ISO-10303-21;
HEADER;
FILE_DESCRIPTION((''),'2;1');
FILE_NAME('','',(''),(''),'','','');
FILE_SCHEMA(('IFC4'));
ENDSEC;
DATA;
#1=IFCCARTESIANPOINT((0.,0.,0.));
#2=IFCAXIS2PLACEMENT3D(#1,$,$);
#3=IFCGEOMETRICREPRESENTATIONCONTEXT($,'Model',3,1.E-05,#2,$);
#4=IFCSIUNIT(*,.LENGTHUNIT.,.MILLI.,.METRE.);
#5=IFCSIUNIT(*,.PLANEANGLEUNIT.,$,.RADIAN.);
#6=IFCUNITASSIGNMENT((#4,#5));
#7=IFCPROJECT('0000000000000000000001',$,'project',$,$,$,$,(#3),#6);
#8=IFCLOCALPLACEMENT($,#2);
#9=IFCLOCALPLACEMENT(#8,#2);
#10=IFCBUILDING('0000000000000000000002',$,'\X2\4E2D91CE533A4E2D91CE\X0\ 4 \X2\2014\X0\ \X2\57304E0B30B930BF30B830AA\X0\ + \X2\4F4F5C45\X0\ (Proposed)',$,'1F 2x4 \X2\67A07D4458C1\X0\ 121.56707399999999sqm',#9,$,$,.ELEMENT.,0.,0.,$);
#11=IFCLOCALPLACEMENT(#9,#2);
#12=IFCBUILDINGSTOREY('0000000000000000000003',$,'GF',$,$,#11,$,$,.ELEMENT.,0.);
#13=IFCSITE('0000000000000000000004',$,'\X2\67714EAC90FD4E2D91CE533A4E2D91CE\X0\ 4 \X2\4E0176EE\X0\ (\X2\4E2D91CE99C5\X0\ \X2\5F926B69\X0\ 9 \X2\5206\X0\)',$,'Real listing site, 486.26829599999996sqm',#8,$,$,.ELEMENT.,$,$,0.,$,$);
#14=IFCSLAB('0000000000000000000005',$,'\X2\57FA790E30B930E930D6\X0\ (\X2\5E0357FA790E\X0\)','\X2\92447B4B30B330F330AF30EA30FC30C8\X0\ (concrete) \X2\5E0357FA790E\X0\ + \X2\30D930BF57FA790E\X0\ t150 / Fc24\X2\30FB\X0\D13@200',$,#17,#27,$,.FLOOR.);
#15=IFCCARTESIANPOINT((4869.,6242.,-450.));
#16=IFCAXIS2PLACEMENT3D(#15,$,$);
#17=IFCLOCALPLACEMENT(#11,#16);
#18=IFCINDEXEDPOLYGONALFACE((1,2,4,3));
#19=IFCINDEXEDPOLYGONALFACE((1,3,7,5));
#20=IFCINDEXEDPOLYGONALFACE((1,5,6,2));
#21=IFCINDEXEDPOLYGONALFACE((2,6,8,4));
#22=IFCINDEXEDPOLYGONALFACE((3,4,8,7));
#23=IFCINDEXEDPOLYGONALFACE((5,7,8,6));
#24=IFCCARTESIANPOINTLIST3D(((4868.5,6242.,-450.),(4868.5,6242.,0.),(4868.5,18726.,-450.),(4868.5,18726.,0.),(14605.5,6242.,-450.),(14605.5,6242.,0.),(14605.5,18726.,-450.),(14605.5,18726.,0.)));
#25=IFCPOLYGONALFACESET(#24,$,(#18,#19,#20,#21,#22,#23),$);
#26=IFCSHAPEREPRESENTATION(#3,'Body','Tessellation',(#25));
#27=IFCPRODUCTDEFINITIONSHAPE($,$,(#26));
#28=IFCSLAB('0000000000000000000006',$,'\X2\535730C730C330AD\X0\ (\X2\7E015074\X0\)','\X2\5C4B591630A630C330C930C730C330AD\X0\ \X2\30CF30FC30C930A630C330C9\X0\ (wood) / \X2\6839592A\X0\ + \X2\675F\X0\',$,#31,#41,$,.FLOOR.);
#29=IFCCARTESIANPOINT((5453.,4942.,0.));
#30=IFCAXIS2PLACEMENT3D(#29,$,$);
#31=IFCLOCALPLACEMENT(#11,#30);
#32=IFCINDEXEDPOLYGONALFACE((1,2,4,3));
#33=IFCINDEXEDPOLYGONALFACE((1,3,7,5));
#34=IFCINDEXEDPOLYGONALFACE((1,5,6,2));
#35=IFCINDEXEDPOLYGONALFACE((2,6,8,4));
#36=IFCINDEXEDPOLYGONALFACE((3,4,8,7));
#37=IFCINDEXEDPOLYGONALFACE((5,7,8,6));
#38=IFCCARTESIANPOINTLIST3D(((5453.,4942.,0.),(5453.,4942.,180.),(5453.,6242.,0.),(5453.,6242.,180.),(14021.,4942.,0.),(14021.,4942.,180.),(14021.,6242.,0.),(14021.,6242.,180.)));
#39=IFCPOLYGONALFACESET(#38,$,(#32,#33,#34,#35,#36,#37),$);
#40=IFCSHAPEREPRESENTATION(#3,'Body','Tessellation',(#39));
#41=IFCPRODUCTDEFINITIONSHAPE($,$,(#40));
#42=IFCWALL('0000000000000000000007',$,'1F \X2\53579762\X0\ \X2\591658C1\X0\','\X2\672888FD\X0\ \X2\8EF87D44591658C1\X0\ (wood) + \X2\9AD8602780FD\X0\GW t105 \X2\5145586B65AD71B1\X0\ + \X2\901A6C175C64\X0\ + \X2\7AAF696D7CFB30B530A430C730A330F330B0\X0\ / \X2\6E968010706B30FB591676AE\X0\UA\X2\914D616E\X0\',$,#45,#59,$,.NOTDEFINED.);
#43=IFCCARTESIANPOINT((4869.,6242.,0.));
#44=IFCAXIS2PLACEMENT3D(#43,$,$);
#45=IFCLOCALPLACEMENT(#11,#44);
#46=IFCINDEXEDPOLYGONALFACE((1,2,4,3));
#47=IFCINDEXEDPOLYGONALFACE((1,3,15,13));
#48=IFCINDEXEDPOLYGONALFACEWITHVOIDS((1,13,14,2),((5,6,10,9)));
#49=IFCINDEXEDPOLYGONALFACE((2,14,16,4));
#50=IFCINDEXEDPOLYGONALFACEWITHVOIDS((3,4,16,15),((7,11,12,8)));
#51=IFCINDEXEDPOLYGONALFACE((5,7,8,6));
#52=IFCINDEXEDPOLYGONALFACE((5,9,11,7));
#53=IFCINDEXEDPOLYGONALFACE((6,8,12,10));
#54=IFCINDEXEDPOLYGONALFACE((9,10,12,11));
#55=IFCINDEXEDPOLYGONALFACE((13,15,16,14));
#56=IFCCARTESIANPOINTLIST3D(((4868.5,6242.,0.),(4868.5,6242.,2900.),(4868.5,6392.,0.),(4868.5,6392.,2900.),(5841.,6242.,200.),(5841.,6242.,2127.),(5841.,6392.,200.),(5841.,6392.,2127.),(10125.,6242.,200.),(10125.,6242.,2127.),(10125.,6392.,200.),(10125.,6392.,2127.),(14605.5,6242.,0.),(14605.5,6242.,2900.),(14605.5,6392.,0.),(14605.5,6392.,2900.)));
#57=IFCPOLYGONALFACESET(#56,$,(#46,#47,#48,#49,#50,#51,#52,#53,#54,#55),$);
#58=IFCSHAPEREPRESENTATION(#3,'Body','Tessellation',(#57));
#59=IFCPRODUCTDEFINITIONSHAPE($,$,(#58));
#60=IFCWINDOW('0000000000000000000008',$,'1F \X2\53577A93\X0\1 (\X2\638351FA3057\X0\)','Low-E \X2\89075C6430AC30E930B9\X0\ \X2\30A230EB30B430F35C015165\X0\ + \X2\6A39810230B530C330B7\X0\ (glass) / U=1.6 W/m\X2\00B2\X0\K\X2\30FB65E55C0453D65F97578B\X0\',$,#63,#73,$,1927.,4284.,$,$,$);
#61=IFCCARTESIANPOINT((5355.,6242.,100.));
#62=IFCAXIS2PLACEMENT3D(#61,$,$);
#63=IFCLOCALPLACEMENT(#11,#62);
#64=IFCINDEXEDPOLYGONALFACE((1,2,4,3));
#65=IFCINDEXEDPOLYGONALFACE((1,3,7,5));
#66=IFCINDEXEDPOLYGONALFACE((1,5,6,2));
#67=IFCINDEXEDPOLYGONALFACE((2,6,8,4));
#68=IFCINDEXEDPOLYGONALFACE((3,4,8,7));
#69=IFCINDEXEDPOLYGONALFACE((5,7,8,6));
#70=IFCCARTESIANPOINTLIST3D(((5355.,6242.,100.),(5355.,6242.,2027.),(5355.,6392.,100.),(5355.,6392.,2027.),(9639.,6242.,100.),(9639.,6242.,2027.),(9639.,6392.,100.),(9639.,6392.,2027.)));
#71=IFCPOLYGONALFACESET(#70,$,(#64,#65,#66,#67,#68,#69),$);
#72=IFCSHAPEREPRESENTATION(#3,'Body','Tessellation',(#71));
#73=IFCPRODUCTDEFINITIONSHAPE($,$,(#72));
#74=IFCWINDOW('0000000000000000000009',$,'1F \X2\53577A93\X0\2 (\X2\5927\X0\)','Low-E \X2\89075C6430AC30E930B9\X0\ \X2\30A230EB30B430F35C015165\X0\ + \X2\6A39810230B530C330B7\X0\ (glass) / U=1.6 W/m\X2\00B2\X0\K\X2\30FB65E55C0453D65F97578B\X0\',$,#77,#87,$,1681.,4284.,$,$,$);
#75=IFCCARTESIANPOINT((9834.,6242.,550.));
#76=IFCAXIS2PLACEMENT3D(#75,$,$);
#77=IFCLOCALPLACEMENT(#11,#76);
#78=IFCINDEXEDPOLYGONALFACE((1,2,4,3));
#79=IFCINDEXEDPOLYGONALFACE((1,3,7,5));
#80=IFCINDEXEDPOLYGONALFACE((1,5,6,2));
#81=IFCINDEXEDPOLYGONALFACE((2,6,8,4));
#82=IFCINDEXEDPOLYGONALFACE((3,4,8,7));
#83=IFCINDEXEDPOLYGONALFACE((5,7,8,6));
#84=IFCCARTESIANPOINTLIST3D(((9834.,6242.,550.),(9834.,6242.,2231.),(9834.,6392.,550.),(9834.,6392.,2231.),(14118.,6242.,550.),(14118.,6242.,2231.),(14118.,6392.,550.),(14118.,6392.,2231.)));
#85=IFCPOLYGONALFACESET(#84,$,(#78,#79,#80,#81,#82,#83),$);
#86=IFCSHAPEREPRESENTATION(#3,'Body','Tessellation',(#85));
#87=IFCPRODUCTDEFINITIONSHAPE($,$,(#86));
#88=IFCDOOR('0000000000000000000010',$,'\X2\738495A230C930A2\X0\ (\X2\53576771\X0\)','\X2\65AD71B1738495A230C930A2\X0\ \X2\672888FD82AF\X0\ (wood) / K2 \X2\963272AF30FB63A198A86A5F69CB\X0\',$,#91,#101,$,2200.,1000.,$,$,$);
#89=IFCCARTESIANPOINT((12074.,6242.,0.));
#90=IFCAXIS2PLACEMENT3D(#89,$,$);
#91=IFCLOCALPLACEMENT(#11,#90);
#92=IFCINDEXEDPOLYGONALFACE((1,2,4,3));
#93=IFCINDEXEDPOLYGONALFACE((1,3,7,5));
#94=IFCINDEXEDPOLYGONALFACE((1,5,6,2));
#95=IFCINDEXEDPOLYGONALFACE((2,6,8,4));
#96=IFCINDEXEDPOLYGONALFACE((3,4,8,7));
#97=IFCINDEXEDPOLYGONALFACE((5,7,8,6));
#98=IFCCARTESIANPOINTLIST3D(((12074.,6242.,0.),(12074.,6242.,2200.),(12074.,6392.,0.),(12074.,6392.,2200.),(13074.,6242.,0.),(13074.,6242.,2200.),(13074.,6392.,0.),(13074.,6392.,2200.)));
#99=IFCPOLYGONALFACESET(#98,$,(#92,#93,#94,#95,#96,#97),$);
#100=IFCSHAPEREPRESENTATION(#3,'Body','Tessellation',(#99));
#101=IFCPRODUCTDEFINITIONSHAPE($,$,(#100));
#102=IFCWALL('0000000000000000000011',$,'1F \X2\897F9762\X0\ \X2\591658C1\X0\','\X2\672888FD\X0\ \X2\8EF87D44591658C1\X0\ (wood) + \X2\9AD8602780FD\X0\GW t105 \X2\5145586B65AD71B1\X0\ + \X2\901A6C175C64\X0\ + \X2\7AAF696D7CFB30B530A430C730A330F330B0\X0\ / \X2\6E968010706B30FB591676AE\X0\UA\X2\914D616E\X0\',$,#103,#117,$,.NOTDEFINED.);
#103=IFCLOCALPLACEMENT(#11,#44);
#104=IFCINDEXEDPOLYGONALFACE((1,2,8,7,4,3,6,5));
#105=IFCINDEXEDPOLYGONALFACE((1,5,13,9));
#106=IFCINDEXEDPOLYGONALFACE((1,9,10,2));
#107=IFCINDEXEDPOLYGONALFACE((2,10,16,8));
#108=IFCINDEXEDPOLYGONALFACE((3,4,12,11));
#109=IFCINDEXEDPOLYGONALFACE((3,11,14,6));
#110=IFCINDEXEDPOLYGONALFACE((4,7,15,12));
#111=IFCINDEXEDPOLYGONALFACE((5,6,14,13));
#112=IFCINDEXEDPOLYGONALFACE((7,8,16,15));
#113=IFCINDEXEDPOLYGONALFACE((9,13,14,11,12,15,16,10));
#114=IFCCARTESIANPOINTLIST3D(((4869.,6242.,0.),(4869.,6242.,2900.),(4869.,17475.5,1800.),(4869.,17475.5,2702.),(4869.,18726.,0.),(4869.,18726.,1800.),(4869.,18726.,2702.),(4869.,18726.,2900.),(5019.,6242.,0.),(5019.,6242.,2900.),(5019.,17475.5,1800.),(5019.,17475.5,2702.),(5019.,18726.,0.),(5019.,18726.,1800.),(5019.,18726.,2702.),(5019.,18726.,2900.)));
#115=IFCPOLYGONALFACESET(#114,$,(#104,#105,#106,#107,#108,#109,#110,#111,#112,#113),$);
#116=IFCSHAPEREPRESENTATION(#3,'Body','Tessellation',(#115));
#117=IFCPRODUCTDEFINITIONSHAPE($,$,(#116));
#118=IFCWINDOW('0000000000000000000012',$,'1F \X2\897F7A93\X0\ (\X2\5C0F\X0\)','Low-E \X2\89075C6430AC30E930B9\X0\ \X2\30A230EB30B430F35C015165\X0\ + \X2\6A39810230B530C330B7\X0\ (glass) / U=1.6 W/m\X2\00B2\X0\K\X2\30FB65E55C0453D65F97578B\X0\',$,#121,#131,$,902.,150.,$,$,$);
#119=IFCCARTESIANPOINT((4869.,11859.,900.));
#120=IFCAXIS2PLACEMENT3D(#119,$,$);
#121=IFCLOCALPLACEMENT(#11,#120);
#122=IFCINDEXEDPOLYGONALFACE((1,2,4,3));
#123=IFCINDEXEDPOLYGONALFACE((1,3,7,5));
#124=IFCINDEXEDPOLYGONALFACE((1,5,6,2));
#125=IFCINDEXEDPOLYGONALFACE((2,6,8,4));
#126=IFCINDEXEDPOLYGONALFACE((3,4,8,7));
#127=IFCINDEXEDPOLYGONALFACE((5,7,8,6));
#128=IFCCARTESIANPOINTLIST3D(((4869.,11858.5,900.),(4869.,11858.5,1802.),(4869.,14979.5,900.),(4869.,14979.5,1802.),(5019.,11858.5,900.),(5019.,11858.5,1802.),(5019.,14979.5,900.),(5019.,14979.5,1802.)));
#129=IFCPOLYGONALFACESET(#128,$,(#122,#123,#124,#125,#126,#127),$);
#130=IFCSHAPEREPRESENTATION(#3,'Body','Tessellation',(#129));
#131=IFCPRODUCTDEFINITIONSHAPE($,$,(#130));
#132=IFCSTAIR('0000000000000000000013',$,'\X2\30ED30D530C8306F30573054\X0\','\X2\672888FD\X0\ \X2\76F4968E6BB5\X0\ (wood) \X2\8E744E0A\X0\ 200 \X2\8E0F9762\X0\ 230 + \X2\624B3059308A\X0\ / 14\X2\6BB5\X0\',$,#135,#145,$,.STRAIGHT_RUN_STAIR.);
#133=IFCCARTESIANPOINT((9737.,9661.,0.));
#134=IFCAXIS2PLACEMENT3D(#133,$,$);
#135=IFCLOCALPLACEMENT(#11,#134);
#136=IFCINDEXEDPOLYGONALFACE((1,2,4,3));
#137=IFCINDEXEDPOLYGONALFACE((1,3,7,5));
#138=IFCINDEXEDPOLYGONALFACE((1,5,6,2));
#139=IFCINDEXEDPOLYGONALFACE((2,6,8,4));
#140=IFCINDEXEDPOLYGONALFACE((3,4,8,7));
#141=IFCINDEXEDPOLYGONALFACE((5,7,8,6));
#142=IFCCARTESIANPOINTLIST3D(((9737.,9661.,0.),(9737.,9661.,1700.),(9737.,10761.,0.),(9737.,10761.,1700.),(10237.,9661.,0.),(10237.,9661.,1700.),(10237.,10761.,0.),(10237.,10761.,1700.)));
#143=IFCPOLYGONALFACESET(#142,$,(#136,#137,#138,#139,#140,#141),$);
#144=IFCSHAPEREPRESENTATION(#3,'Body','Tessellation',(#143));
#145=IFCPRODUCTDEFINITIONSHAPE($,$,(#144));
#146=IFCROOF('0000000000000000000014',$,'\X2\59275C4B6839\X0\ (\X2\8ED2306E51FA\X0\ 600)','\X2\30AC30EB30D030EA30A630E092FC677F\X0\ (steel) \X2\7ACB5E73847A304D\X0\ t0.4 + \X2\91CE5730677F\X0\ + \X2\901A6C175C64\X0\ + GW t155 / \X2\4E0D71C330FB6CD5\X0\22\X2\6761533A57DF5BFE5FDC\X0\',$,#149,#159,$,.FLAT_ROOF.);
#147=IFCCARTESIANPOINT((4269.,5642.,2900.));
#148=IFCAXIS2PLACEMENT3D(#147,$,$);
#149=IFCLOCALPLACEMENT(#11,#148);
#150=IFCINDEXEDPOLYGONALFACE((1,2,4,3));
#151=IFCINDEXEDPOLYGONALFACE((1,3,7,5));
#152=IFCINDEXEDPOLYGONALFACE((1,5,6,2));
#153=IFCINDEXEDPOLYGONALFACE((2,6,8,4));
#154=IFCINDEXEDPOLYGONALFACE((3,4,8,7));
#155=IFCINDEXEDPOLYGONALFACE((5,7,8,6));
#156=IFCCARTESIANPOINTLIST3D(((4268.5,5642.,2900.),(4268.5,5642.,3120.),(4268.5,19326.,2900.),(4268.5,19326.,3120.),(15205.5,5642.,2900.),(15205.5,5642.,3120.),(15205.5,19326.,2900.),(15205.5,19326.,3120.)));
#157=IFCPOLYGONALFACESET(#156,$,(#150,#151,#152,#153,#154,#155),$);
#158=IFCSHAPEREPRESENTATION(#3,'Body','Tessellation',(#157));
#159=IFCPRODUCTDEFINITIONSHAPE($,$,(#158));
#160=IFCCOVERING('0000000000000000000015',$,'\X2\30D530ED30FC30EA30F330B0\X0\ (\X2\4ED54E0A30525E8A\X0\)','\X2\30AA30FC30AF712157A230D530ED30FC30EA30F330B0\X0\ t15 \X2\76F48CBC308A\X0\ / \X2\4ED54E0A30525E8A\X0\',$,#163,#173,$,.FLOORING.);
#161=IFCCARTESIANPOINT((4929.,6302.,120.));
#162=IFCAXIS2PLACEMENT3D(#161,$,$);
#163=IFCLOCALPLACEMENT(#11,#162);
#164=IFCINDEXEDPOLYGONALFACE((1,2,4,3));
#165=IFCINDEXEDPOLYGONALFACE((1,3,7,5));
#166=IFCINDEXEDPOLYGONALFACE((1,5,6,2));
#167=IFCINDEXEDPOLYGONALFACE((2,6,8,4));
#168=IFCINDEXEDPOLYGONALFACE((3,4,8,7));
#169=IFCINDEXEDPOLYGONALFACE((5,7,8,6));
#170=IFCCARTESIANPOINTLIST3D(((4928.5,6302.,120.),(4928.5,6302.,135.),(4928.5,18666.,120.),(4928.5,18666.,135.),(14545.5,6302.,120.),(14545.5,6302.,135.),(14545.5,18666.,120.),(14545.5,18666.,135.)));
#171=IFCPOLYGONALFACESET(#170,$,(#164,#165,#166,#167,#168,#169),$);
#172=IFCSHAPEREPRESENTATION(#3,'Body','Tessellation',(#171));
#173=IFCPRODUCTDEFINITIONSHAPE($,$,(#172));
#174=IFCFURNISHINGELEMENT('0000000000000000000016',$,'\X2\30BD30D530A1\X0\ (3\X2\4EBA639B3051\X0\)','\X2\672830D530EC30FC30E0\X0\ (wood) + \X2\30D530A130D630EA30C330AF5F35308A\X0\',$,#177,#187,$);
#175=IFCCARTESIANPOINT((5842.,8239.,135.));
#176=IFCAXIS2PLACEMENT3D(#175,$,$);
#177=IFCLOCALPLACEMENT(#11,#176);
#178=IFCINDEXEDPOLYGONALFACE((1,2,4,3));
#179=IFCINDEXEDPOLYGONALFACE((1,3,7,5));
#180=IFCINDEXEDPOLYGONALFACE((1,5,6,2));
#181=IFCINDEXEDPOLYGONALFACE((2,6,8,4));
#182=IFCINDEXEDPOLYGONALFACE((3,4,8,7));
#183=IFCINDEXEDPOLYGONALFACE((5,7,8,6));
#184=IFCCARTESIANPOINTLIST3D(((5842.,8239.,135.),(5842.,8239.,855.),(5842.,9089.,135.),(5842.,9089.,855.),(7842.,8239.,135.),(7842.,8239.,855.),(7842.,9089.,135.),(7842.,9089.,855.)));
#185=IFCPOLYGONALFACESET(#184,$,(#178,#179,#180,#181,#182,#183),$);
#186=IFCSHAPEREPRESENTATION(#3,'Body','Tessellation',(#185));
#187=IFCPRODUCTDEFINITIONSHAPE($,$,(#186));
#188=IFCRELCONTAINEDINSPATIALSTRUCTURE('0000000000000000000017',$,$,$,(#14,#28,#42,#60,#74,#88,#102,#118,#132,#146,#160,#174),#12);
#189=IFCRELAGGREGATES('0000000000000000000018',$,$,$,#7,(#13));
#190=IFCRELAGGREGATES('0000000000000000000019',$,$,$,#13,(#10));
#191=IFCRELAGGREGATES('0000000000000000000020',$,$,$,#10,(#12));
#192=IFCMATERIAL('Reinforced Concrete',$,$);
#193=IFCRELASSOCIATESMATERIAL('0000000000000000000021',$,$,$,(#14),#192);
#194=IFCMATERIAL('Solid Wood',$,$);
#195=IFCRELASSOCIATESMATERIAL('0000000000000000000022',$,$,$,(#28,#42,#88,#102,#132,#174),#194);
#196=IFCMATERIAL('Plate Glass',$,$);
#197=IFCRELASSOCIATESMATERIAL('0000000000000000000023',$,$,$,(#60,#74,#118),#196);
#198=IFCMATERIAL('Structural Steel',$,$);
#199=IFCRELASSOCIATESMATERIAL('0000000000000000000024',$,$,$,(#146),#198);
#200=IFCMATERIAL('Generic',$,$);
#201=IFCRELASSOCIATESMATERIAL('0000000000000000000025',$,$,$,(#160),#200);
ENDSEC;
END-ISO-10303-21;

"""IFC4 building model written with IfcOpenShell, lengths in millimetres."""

from ifc_helpers import new_model, si_unit, frame, frame_2d, origin, place, context, project, spatial, rectangle, extrude, material, element, fill, save


model = new_model("IFC4")

# Units and contexts
model_context = context("Model", 3, precision=1e-05, world=origin())
ifc_project = project(units=[si_unit("LENGTHUNIT", "METRE", prefix="MILLI"), si_unit("PLANEANGLEUNIT", "RADIAN")], contexts=[model_context])

# Site, building, storey
site_placement = place(None, origin())
site = spatial("IfcSite", under=ifc_project, at=site_placement, Name="東京都中野区中野 4 丁目 (中野駅 徒歩 9 分)", ObjectType="Real listing site, 486.26829599999996sqm", CompositionType="ELEMENT", RefElevation=0.0)
building_placement = place(site_placement, origin())
building = spatial("IfcBuilding", under=site, at=building_placement, Name="中野区中野 4 — 地下スタジオ + 住居 (Proposed)", ObjectType="1F 2x4 枠組壁 121.56707399999999sqm", CompositionType="ELEMENT", ElevationOfRefHeight=0.0, ElevationOfTerrain=0.0)
storey_placement = place(building_placement, origin())
storey = spatial("IfcBuildingStorey", under=building, at=storey_placement, Name="GF", CompositionType="ELEMENT", Elevation=0.0)

# Slabs
ifc_material_1 = material(Name="Reinforced Concrete")
slab_1_placement = place(storey_placement, frame((4869.0, 6242.0, -450.0)))
element("IfcSlab", 1, at=slab_1_placement, inside=storey, material=ifc_material_1, Name="基礎スラブ (布基礎)", Description="鉄筋コンクリート (concrete) 布基礎 + ベタ基礎 t150 / Fc24・D13@200", PredefinedType="FLOOR", context=model_context, shape_type="SweptSolid", body=[
    extrude(rectangle(XDim=9737.0, YDim=12484.0, at=frame_2d((4868.0, 6242.0))), frame((4869.0, 6242.0, -450.0)), (0.0, 0.0, 1.0), 450.0),
])
ifc_material_2 = material(Name="Solid Wood")
slab_2_placement = place(storey_placement, frame((5453.0, 4942.0, 0.0)))
element("IfcSlab", 2, at=slab_2_placement, inside=storey, material=ifc_material_2, Name="南デッキ (縁側)", Description="屋外ウッドデッキ ハードウッド (wood) / 根太 + 束", PredefinedType="FLOOR", context=model_context, shape_type="SweptSolid", body=[
    extrude(rectangle(XDim=8568.0, YDim=1300.0, at=frame_2d((4284.0, 650.0))), frame((5453.0, 4942.0, 0.0)), (0.0, 0.0, 1.0), 180.0),
])

# Wall, openings, windows, door
wall_1_placement = place(storey_placement, frame((4869.0, 6242.0, 0.0)))
wall_1 = element("IfcWall", 3, at=wall_1_placement, inside=storey, material=ifc_material_2, Name="1F 南面 外壁", Description="木製 軸組外壁 (wood) + 高性能GW t105 充填断熱 + 通気層 + 窯業系サイディング / 準耐火・外皮UA配慮", PredefinedType="NOTDEFINED", context=model_context, shape_type="SweptSolid", body=[
    extrude(rectangle(XDim=9737.0, YDim=150.0, at=frame_2d((4868.0, 75.0))), frame((4869.0, 6242.0, 0.0)), (0.0, 0.0, 1.0), 2900.0),
])
opening_1_placement = place(storey_placement, frame((5355.0, 6242.0, 100.0)))
opening_1 = element("IfcOpeningElement", 4, at=opening_1_placement, cuts=wall_1, PredefinedType="NOTDEFINED", context=model_context, shape_type="SweptSolid", body=[
    extrude(rectangle(XDim=4284.0, YDim=150.0, at=frame_2d((2142.0, 75.0))), frame((5355.0, 6242.0, 100.0)), (0.0, 0.0, 1.0), 1927.0),
])
opening_2_placement = place(storey_placement, frame((9834.0, 6242.0, 550.0)))
opening_2 = element("IfcOpeningElement", 5, at=opening_2_placement, cuts=wall_1, PredefinedType="NOTDEFINED", context=model_context, shape_type="SweptSolid", body=[
    extrude(rectangle(XDim=4284.0, YDim=150.0, at=frame_2d((2142.0, 75.0))), frame((9834.0, 6242.0, 550.0)), (0.0, 0.0, 1.0), 1681.0),
])
opening_3_placement = place(storey_placement, frame((12074.0, 6242.0, 0.0)))
opening_3 = element("IfcOpeningElement", 6, at=opening_3_placement, cuts=wall_1, PredefinedType="NOTDEFINED", context=model_context, shape_type="SweptSolid", body=[
    extrude(rectangle(XDim=1000.0, YDim=150.0, at=frame_2d((500.0, 75.0))), frame((12074.0, 6242.0, 0.0)), (0.0, 0.0, 1.0), 2200.0),
])
ifc_material_3 = material(Name="Plate Glass")
window_1_placement = place(storey_placement, frame((5355.0, 6242.0, 100.0)))
window_1 = element("IfcWindow", 7, at=window_1_placement, inside=storey, material=ifc_material_3, Name="1F 南窓1 (掃出し)", Description="Low-E 複層ガラス アルゴン封入 + 樹脂サッシ (glass) / U=1.6 W/m²K・日射取得型", OverallHeight=1927.0, OverallWidth=4284.0, context=model_context, shape_type="SweptSolid", body=[
    extrude(rectangle(XDim=4284.0, YDim=150.0, at=frame_2d((2142.0, 75.0))), frame((5355.0, 6242.0, 100.0)), (0.0, 0.0, 1.0), 1927.0),
])
fill(opening_1, window_1)
window_2_placement = place(storey_placement, frame((9834.0, 6242.0, 550.0)))
window_2 = element("IfcWindow", 8, at=window_2_placement, inside=storey, material=ifc_material_3, Name="1F 南窓2 (大)", Description="Low-E 複層ガラス アルゴン封入 + 樹脂サッシ (glass) / U=1.6 W/m²K・日射取得型", OverallHeight=1681.0, OverallWidth=4284.0, context=model_context, shape_type="SweptSolid", body=[
    extrude(rectangle(XDim=4284.0, YDim=150.0, at=frame_2d((2142.0, 75.0))), frame((9834.0, 6242.0, 550.0)), (0.0, 0.0, 1.0), 1681.0),
])
fill(opening_2, window_2)
door_placement = place(storey_placement, frame((12074.0, 6242.0, 0.0)))
door = element("IfcDoor", 9, at=door_placement, inside=storey, material=ifc_material_2, Name="玄関ドア (南東)", Description="断熱玄関ドア 木製芯 (wood) / K2 防犯・採風機構", OverallHeight=2200.0, OverallWidth=1000.0, context=model_context, shape_type="SweptSolid", body=[
    extrude(rectangle(XDim=1000.0, YDim=150.0, at=frame_2d((500.0, 75.0))), frame((12074.0, 6242.0, 0.0)), (0.0, 0.0, 1.0), 2200.0),
])
fill(opening_3, door)

# Wall, opening, window
wall_2_placement = place(storey_placement, frame((4869.0, 6242.0, 0.0)))
wall_2 = element("IfcWall", 10, at=wall_2_placement, inside=storey, material=ifc_material_2, Name="1F 西面 外壁", Description="木製 軸組外壁 (wood) + 高性能GW t105 充填断熱 + 通気層 + 窯業系サイディング / 準耐火・外皮UA配慮", PredefinedType="NOTDEFINED", context=model_context, shape_type="SweptSolid", body=[
    extrude(rectangle(XDim=150.0, YDim=12484.0, at=frame_2d((75.0, 6242.0))), frame((4869.0, 6242.0, 0.0)), (0.0, 0.0, 1.0), 2900.0),
])
opening_4_placement = place(storey_placement, frame((4869.0, 11859.0, 900.0)))
opening_4 = element("IfcOpeningElement", 11, at=opening_4_placement, cuts=wall_2, PredefinedType="NOTDEFINED", context=model_context, shape_type="SweptSolid", body=[
    extrude(rectangle(XDim=150.0, YDim=3121.0, at=frame_2d((75.0, 1560.0))), frame((4869.0, 11859.0, 900.0)), (0.0, 0.0, 1.0), 902.0),
])
window_3_placement = place(storey_placement, frame((4869.0, 11859.0, 900.0)))
window_3 = element("IfcWindow", 12, at=window_3_placement, inside=storey, material=ifc_material_3, Name="1F 西窓 (小)", Description="Low-E 複層ガラス アルゴン封入 + 樹脂サッシ (glass) / U=1.6 W/m²K・日射取得型", OverallHeight=902.0, OverallWidth=150.0, context=model_context, shape_type="SweptSolid", body=[
    extrude(rectangle(XDim=150.0, YDim=3121.0, at=frame_2d((75.0, 1560.0))), frame((4869.0, 11859.0, 900.0)), (0.0, 0.0, 1.0), 902.0),
])
fill(opening_4, window_3)

# Stair
stair_placement = place(storey_placement, frame((9737.0, 9661.0, 0.0)))
element("IfcStair", 13, at=stair_placement, inside=storey, material=ifc_material_2, Name="ロフトはしご", Description="木製 直階段 (wood) 蹴上 200 踏面 230 + 手すり / 14段", PredefinedType="STRAIGHT_RUN_STAIR", context=model_context, shape_type="SweptSolid", body=[
    extrude(rectangle(XDim=500.0, YDim=1100.0, at=frame_2d((250.0, 550.0))), frame((9737.0, 9661.0, 0.0)), (0.0, 0.0, 1.0), 1700.0),
])

# Roof
ifc_material_4 = material(Name="Structural Steel")
roof_placement = place(storey_placement, frame((4269.0, 5642.0, 2900.0)))
element("IfcRoof", 14, at=roof_placement, inside=storey, material=ifc_material_4, Name="大屋根 (軒の出 600)", Description="ガルバリウム鋼板 (steel) 立平葺き t0.4 + 野地板 + 通気層 + GW t155 / 不燃・法22条区域対応", PredefinedType="FLAT_ROOF", context=model_context, shape_type="SweptSolid", body=[
    extrude(rectangle(XDim=10937.0, YDim=13684.0, at=frame_2d((5468.0, 6842.0))), frame((4269.0, 5642.0, 2900.0)), (0.0, 0.0, 1.0), 220.0),
])

# Covering
ifc_material_5 = material(Name="Generic")
covering_placement = place(storey_placement, frame((4929.0, 6302.0, 120.0)))
element("IfcCovering", 15, at=covering_placement, inside=storey, material=ifc_material_5, Name="フローリング (仕上げ床)", Description="オーク無垢フローリング t15 直貼り / 仕上げ床", PredefinedType="FLOORING", context=model_context, shape_type="SweptSolid", body=[
    extrude(rectangle(XDim=9617.0, YDim=12364.0, at=frame_2d((4808.0, 6182.0))), frame((4929.0, 6302.0, 120.0)), (0.0, 0.0, 1.0), 15.0),
])

# Furnishing element
furnishing_1_placement = place(storey_placement, frame((5842.0, 8239.0, 135.0)))
element("IfcFurnishingElement", 16, at=furnishing_1_placement, inside=storey, material=ifc_material_2, Name="ソファ (3人掛け)", Description="木フレーム (wood) + ファブリック張り", context=model_context, shape_type="SweptSolid", body=[
    extrude(rectangle(XDim=2000.0, YDim=850.0, at=frame_2d((1000.0, 425.0))), frame((5842.0, 8239.0, 135.0)), (0.0, 0.0, 1.0), 720.0),
])

save(model, "model.ifc")
